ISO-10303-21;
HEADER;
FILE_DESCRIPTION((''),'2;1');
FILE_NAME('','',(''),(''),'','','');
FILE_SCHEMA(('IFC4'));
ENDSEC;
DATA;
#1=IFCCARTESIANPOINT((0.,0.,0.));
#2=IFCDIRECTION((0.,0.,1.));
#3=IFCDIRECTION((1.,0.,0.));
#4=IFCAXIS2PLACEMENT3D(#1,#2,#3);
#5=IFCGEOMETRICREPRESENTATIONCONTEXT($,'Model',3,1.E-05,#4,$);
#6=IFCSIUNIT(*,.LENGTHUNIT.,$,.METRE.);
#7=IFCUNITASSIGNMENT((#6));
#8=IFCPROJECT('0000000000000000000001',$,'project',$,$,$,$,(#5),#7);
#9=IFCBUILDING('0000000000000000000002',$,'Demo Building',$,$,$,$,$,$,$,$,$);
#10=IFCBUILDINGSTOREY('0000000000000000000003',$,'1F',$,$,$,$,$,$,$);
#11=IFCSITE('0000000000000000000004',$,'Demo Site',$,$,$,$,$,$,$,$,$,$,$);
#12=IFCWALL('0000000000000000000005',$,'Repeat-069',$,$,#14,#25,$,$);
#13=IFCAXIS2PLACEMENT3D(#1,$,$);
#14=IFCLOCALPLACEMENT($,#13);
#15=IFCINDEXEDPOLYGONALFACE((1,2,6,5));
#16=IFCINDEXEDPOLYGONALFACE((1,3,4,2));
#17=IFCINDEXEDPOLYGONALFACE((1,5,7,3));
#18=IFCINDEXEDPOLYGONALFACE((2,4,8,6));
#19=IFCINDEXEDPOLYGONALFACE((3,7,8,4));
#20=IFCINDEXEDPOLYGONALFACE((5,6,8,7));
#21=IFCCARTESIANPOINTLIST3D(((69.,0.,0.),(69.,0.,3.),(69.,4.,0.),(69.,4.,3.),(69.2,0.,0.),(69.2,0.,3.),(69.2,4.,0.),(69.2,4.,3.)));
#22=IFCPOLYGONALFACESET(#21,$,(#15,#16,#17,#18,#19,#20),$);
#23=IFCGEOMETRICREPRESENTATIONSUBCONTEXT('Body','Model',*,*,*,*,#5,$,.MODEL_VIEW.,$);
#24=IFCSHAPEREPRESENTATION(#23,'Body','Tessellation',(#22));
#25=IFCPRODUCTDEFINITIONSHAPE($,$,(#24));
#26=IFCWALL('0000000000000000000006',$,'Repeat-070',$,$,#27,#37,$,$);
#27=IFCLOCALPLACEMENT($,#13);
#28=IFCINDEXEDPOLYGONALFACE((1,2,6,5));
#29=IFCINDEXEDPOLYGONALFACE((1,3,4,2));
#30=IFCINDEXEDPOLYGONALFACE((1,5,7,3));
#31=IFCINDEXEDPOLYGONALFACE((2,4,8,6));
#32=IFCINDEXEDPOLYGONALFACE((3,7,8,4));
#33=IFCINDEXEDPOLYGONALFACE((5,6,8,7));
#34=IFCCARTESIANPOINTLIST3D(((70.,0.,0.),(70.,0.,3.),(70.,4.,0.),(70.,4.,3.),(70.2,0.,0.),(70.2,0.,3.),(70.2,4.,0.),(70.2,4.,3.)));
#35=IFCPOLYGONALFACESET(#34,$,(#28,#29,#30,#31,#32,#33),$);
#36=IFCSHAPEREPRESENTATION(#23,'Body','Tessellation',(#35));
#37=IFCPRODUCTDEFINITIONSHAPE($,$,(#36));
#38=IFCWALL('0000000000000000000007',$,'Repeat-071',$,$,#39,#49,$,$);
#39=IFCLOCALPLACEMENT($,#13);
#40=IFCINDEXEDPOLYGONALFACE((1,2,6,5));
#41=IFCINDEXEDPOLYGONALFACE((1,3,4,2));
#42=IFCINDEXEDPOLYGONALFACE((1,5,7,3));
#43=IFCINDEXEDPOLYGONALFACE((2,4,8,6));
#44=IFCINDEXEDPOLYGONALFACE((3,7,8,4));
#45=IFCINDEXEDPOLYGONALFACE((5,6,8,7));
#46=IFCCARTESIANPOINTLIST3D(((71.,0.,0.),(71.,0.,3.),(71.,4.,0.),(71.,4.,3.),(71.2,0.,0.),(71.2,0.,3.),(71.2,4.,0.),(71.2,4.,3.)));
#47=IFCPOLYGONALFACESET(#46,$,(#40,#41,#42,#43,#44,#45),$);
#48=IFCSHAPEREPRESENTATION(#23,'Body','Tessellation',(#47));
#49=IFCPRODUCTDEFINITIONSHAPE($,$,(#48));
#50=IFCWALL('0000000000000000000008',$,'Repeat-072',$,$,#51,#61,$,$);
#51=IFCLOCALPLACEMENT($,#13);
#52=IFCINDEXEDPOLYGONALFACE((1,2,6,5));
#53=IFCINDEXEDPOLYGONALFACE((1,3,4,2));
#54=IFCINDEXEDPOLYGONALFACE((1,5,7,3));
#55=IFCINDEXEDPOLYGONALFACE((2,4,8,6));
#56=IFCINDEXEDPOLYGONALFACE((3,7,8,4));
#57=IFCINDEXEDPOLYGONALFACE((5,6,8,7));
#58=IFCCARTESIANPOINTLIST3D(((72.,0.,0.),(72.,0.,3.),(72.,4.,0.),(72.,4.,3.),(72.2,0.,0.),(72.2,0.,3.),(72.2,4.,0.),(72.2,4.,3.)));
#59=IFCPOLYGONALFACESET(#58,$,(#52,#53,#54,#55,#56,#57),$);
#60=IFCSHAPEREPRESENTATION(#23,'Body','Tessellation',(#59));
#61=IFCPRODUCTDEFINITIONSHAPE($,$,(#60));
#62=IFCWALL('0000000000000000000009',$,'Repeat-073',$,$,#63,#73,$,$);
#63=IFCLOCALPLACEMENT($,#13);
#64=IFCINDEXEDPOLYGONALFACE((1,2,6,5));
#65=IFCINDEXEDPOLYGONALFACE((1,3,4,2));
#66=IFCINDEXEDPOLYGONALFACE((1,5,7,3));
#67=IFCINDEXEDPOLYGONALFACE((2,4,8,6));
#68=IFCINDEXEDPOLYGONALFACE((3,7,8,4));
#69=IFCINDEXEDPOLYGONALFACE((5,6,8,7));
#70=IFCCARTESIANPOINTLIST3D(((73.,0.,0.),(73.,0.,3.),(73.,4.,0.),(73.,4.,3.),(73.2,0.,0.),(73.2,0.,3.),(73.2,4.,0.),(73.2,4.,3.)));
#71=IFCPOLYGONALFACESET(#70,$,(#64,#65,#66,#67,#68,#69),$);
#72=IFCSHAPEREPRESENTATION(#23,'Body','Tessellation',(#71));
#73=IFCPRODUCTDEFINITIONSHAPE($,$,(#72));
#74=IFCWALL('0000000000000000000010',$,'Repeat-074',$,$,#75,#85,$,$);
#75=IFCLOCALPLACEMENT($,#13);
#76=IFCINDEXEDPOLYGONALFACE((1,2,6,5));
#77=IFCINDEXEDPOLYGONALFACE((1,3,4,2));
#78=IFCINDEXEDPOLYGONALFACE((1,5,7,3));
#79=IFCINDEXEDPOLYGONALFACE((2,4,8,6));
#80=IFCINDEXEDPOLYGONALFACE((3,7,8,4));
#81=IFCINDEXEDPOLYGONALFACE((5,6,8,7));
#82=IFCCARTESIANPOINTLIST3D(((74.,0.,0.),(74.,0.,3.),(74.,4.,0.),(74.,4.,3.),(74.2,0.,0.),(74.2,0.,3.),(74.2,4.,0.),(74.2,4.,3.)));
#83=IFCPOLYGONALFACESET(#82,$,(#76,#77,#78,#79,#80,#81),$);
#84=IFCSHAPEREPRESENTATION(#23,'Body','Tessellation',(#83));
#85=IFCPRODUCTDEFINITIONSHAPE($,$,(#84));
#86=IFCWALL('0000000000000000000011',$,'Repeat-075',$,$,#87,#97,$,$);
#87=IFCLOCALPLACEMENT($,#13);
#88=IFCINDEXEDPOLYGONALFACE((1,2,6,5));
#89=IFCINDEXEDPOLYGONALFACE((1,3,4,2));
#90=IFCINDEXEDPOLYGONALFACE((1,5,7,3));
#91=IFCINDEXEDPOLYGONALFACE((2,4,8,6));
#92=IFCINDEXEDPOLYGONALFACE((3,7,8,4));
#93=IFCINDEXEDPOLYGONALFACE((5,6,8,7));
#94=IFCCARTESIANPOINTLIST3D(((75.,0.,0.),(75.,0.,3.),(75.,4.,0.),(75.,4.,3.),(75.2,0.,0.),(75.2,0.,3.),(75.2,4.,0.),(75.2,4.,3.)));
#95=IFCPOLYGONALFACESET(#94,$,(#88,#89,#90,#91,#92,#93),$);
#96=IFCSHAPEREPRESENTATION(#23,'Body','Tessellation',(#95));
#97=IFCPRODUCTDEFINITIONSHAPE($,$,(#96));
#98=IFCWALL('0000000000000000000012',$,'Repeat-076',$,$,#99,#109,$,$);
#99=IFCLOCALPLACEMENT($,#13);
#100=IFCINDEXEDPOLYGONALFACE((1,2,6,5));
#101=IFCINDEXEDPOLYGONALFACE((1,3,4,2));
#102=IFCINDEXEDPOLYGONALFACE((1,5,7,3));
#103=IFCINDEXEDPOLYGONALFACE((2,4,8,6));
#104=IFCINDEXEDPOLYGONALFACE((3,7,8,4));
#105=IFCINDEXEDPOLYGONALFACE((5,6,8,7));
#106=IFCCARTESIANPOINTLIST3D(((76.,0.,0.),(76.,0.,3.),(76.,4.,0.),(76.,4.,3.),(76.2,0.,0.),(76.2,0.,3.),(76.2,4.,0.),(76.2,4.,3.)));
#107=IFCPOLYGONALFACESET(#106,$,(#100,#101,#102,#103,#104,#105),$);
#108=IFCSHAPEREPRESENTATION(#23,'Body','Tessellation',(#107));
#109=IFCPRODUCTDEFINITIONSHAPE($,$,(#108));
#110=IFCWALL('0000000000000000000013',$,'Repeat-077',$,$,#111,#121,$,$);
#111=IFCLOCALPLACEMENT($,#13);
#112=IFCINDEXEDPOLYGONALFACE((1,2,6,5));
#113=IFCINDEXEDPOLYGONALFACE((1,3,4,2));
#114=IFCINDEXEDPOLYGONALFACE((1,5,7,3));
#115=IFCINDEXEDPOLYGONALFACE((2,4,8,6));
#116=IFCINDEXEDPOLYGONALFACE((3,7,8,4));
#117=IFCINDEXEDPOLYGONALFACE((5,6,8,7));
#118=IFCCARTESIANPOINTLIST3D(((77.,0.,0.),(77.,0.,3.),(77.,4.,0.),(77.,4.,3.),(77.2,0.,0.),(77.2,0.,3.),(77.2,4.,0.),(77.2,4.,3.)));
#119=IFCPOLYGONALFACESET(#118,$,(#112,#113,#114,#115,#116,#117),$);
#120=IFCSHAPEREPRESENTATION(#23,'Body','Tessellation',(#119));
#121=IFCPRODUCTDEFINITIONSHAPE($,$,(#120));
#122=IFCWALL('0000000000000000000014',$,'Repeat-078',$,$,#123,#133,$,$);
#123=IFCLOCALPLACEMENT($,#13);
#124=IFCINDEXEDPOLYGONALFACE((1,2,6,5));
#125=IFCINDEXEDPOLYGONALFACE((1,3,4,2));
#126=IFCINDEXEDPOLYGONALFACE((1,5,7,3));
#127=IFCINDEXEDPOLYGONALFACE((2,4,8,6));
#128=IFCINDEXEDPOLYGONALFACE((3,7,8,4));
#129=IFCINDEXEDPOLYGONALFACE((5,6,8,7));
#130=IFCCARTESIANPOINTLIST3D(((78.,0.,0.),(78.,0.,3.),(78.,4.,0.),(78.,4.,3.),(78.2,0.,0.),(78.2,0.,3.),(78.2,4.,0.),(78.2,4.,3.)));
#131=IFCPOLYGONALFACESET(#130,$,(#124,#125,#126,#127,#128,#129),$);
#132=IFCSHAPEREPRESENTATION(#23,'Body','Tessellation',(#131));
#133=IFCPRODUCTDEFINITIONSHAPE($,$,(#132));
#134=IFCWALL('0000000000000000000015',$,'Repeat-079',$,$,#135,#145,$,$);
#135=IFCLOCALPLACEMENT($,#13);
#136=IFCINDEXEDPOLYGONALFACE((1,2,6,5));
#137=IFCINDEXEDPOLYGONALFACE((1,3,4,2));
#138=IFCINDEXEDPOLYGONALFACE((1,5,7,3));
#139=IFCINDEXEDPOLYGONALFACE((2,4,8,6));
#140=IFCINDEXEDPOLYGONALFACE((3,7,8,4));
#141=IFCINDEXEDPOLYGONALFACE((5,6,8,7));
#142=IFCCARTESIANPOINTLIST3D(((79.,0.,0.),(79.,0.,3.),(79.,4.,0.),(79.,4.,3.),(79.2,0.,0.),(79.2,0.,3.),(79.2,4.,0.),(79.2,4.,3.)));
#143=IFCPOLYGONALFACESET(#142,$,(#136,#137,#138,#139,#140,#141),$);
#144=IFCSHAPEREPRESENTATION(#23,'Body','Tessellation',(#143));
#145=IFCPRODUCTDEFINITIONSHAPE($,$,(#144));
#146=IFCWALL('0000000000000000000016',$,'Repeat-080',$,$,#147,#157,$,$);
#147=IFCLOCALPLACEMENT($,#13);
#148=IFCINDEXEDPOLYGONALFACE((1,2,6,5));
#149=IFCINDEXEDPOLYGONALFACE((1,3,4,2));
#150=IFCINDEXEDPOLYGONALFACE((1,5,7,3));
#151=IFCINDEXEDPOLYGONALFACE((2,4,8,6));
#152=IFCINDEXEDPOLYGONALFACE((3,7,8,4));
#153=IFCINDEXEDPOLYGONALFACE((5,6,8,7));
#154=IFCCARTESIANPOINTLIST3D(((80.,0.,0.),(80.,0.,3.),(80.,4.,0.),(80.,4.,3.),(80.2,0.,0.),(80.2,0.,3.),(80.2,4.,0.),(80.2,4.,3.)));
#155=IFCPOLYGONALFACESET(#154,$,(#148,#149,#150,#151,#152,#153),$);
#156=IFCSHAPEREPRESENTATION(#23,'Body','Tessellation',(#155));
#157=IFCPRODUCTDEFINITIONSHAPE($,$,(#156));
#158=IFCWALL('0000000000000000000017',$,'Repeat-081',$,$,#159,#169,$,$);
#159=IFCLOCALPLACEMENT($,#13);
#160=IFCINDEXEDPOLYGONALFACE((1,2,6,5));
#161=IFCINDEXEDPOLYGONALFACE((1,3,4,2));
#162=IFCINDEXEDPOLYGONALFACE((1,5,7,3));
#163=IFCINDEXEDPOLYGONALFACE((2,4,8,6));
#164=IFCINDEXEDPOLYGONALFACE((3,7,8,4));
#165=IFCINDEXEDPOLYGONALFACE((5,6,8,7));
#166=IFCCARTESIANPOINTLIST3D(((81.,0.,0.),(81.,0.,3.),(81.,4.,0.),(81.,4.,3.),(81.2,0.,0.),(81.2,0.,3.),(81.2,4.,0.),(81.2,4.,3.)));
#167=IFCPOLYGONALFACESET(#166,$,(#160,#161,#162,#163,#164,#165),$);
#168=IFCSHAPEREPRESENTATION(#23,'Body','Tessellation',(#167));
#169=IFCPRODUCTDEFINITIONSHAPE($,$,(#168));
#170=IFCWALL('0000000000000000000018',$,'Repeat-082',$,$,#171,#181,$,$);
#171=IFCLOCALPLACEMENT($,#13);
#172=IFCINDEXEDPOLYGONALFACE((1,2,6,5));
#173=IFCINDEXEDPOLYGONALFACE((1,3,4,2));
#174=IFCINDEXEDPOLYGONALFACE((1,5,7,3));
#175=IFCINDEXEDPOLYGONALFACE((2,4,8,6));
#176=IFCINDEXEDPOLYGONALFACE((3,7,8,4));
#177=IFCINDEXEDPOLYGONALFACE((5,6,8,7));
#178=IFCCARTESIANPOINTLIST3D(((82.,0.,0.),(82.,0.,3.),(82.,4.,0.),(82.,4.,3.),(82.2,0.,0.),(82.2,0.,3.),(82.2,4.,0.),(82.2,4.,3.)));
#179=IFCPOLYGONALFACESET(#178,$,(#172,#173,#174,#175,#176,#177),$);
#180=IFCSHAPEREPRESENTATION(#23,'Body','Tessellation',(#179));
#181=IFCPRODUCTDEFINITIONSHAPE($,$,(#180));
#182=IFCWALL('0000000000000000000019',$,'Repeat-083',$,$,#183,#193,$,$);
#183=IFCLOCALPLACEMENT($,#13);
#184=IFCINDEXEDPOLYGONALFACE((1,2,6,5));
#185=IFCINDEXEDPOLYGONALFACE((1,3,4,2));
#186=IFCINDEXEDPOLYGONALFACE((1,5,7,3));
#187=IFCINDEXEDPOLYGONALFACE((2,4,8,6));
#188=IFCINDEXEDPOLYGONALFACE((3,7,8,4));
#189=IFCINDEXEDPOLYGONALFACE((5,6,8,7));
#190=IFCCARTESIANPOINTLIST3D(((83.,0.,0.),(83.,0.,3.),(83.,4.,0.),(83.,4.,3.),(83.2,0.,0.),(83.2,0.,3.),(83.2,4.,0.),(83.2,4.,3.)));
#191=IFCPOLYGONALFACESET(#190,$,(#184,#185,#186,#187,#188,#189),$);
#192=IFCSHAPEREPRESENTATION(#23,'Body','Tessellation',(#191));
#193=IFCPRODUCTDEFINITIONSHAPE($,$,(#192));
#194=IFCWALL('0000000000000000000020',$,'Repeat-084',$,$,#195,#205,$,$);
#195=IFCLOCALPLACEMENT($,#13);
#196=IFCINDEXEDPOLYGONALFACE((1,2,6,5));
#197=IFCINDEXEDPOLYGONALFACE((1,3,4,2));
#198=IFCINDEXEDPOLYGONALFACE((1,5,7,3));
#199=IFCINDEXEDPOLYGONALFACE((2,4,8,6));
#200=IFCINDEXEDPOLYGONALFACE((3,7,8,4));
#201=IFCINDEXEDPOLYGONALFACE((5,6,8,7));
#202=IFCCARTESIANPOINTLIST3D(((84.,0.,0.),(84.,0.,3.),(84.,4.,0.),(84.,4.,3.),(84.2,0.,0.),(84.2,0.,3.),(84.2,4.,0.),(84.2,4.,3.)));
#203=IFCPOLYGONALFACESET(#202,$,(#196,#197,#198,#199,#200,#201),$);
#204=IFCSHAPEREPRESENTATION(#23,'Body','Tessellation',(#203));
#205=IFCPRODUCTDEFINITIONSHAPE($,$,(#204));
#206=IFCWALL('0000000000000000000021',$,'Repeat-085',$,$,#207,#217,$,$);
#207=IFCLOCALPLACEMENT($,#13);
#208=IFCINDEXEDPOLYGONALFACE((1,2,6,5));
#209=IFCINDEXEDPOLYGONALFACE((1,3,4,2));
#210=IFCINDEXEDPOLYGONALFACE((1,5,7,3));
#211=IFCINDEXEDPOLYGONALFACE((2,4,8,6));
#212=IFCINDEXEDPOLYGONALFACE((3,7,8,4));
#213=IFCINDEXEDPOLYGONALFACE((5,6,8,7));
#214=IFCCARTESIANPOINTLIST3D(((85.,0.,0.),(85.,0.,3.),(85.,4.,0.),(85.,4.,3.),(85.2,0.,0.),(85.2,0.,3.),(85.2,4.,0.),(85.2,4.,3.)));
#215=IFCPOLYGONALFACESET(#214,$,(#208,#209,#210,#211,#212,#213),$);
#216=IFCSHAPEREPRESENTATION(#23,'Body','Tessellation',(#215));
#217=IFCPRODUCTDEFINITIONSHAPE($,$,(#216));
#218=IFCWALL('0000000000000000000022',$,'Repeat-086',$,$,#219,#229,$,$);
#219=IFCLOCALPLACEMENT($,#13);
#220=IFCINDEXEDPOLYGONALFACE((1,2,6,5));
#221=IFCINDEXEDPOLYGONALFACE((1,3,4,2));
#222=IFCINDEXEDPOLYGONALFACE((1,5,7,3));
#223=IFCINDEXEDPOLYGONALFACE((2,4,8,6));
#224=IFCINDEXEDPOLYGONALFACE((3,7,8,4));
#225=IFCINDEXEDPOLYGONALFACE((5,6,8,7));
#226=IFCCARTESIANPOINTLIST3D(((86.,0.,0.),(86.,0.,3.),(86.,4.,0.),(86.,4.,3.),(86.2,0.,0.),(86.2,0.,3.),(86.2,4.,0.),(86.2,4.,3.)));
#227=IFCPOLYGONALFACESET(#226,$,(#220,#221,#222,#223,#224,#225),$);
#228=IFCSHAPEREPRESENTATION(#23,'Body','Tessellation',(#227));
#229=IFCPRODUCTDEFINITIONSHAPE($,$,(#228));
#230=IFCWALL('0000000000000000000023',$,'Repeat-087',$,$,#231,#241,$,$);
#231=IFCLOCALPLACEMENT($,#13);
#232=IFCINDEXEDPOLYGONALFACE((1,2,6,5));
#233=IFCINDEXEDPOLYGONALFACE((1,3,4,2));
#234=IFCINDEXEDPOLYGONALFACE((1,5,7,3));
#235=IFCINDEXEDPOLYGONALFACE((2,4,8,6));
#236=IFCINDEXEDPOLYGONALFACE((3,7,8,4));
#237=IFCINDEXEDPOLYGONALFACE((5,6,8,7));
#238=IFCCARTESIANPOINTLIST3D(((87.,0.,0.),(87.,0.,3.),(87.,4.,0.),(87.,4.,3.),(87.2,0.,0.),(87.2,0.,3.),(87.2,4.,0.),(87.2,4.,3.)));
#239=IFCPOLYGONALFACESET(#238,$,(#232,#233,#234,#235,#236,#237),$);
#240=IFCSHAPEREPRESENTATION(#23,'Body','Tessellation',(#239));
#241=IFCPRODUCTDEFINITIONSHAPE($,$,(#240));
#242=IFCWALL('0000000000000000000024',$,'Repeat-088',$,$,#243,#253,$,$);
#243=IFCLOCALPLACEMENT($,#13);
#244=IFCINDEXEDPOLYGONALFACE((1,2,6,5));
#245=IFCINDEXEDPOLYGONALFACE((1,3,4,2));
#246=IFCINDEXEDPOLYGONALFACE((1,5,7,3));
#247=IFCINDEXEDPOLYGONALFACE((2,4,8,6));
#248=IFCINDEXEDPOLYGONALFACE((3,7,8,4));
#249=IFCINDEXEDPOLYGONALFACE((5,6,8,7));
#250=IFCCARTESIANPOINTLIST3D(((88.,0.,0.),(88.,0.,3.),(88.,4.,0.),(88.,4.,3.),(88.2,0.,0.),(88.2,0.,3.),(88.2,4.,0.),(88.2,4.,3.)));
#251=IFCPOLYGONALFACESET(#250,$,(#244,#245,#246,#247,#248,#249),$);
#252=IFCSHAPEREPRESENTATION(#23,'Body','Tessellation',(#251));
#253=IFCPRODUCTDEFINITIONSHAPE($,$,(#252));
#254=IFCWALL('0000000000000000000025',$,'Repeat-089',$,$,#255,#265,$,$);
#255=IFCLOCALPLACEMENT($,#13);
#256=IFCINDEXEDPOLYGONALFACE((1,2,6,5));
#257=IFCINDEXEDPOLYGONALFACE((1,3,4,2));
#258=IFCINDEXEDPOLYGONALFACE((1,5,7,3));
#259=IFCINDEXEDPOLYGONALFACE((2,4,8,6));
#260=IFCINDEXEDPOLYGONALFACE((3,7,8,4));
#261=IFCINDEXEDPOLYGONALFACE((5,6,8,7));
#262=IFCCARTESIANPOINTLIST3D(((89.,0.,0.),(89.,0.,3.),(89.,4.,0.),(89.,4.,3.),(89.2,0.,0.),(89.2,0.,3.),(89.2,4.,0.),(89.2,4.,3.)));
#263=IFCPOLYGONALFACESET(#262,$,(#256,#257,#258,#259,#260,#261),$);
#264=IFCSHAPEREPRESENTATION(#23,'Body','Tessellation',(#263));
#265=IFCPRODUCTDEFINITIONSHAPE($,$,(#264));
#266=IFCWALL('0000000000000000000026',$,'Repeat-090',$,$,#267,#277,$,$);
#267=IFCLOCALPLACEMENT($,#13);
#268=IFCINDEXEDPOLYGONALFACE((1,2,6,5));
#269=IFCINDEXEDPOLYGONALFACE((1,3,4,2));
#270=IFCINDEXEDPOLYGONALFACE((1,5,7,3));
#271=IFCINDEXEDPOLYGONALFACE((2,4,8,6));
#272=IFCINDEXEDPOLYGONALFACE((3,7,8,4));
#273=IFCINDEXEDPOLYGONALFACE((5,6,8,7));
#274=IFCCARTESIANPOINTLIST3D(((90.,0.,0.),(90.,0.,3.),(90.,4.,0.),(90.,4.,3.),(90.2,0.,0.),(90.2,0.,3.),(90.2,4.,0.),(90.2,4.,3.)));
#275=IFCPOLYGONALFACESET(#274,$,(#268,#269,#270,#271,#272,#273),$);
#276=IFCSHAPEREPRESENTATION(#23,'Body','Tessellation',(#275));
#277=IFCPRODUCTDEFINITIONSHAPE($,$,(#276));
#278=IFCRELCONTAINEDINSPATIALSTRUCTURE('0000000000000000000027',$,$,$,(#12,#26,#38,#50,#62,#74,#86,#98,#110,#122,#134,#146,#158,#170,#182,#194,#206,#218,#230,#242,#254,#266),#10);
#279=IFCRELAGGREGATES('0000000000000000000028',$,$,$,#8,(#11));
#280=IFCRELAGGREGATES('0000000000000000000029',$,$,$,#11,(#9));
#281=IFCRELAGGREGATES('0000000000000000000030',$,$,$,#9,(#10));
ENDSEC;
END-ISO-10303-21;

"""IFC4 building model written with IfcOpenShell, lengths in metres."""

from ifc_helpers import new_model, entity, si_unit, frame, origin_with_axes, place, context, subcontext, project, spatial, element, save


model = new_model("IFC4")

# Units and contexts
model_context = context("Model", 3, precision=1e-05, world=origin_with_axes())
body_context = subcontext(model_context, "Body", "Model", "MODEL_VIEW")
ifc_project = project(units=[si_unit("LENGTHUNIT", "METRE")], contexts=[model_context])

# Site, building, storey
site = spatial("IfcSite", under=ifc_project, Name="Demo Site")
building = spatial("IfcBuilding", under=site, Name="Demo Building")
storey = spatial("IfcBuildingStorey", under=building, Name="1F")

# Walls
for number, where, z_axis, x_axis, name in (
    (1, (69.0, 0.0, 0.0), (0.0, 0.0, 1.0), (1.0, 0.0, 0.0), "Repeat-069"),
    (2, (70.0, 0.0, 0.0), (0.0, 0.0, 1.0), (1.0, 0.0, 0.0), "Repeat-070"),
    (3, (71.0, 0.0, 0.0), (0.0, 0.0, 1.0), (1.0, 0.0, 0.0), "Repeat-071"),
    (4, (72.0, 0.0, 0.0), (0.0, 0.0, 1.0), (1.0, 0.0, 0.0), "Repeat-072"),
    (5, (73.0, 0.0, 0.0), (0.0, 0.0, 1.0), (1.0, 0.0, 0.0), "Repeat-073"),
    (6, (74.0, 0.0, 0.0), (0.0, 0.0, 1.0), (1.0, 0.0, 0.0), "Repeat-074"),
    (7, (75.0, 0.0, 0.0), (0.0, 0.0, 1.0), (1.0, 0.0, 0.0), "Repeat-075"),
    (8, (76.0, 0.0, 0.0), (0.0, 0.0, 1.0), (1.0, 0.0, 0.0), "Repeat-076"),
    (9, (77.0, 0.0, 0.0), (0.0, 0.0, 1.0), (1.0, 0.0, 0.0), "Repeat-077"),
    (10, (78.0, 0.0, 0.0), (0.0, 0.0, 1.0), (1.0, 0.0, 0.0), "Repeat-078"),
    (11, (79.0, 0.0, 0.0), (0.0, 0.0, 1.0), (1.0, 0.0, 0.0), "Repeat-079"),
    (12, (80.0, 0.0, 0.0), (0.0, 0.0, 1.0), (1.0, 0.0, 0.0), "Repeat-080"),
    (13, (81.0, 0.0, 0.0), (0.0, 0.0, 1.0), (1.0, 0.0, 0.0), "Repeat-081"),
    (14, (82.0, 0.0, 0.0), (0.0, 0.0, 1.0), (1.0, 0.0, 0.0), "Repeat-082"),
    (15, (83.0, 0.0, 0.0), (0.0, 0.0, 1.0), (1.0, 0.0, 0.0), "Repeat-083"),
    (16, (84.0, 0.0, 0.0), (0.0, 0.0, 1.0), (1.0, 0.0, 0.0), "Repeat-084"),
    (17, (85.0, 0.0, 0.0), (0.0, 0.0, 1.0), (1.0, 0.0, 0.0), "Repeat-085"),
    (18, (86.0, 0.0, 0.0), (0.0, 0.0, 1.0), (1.0, 0.0, 0.0), "Repeat-086"),
    (19, (87.0, 0.0, 0.0), (0.0, 0.0, 1.0), (1.0, 0.0, 0.0), "Repeat-087"),
    (20, (88.0, 0.0, 0.0), (0.0, 0.0, 1.0), (1.0, 0.0, 0.0), "Repeat-088"),
    (21, (89.0, 0.0, 0.0), (0.0, 0.0, 1.0), (1.0, 0.0, 0.0), "Repeat-089"),
    (22, (90.0, 0.0, 0.0), (0.0, 0.0, 1.0), (1.0, 0.0, 0.0), "Repeat-090"),
):
    element("IfcWall", number, at=place(None, frame(where, z_axis=z_axis, x_axis=x_axis)), inside=storey, Name=name, context=body_context, shape_type="CSG", body=[
        entity("IfcBlock", entity("IfcAxis2Placement3D", entity("IfcCartesianPoint", [0.0, 0.0, 0.0]), entity("IfcDirection", [0.0, 0.0, 1.0]), entity("IfcDirection", [1.0, 0.0, 0.0])), 0.2, 4.0, 3.0),
    ])

save(model, "model.ifc")
